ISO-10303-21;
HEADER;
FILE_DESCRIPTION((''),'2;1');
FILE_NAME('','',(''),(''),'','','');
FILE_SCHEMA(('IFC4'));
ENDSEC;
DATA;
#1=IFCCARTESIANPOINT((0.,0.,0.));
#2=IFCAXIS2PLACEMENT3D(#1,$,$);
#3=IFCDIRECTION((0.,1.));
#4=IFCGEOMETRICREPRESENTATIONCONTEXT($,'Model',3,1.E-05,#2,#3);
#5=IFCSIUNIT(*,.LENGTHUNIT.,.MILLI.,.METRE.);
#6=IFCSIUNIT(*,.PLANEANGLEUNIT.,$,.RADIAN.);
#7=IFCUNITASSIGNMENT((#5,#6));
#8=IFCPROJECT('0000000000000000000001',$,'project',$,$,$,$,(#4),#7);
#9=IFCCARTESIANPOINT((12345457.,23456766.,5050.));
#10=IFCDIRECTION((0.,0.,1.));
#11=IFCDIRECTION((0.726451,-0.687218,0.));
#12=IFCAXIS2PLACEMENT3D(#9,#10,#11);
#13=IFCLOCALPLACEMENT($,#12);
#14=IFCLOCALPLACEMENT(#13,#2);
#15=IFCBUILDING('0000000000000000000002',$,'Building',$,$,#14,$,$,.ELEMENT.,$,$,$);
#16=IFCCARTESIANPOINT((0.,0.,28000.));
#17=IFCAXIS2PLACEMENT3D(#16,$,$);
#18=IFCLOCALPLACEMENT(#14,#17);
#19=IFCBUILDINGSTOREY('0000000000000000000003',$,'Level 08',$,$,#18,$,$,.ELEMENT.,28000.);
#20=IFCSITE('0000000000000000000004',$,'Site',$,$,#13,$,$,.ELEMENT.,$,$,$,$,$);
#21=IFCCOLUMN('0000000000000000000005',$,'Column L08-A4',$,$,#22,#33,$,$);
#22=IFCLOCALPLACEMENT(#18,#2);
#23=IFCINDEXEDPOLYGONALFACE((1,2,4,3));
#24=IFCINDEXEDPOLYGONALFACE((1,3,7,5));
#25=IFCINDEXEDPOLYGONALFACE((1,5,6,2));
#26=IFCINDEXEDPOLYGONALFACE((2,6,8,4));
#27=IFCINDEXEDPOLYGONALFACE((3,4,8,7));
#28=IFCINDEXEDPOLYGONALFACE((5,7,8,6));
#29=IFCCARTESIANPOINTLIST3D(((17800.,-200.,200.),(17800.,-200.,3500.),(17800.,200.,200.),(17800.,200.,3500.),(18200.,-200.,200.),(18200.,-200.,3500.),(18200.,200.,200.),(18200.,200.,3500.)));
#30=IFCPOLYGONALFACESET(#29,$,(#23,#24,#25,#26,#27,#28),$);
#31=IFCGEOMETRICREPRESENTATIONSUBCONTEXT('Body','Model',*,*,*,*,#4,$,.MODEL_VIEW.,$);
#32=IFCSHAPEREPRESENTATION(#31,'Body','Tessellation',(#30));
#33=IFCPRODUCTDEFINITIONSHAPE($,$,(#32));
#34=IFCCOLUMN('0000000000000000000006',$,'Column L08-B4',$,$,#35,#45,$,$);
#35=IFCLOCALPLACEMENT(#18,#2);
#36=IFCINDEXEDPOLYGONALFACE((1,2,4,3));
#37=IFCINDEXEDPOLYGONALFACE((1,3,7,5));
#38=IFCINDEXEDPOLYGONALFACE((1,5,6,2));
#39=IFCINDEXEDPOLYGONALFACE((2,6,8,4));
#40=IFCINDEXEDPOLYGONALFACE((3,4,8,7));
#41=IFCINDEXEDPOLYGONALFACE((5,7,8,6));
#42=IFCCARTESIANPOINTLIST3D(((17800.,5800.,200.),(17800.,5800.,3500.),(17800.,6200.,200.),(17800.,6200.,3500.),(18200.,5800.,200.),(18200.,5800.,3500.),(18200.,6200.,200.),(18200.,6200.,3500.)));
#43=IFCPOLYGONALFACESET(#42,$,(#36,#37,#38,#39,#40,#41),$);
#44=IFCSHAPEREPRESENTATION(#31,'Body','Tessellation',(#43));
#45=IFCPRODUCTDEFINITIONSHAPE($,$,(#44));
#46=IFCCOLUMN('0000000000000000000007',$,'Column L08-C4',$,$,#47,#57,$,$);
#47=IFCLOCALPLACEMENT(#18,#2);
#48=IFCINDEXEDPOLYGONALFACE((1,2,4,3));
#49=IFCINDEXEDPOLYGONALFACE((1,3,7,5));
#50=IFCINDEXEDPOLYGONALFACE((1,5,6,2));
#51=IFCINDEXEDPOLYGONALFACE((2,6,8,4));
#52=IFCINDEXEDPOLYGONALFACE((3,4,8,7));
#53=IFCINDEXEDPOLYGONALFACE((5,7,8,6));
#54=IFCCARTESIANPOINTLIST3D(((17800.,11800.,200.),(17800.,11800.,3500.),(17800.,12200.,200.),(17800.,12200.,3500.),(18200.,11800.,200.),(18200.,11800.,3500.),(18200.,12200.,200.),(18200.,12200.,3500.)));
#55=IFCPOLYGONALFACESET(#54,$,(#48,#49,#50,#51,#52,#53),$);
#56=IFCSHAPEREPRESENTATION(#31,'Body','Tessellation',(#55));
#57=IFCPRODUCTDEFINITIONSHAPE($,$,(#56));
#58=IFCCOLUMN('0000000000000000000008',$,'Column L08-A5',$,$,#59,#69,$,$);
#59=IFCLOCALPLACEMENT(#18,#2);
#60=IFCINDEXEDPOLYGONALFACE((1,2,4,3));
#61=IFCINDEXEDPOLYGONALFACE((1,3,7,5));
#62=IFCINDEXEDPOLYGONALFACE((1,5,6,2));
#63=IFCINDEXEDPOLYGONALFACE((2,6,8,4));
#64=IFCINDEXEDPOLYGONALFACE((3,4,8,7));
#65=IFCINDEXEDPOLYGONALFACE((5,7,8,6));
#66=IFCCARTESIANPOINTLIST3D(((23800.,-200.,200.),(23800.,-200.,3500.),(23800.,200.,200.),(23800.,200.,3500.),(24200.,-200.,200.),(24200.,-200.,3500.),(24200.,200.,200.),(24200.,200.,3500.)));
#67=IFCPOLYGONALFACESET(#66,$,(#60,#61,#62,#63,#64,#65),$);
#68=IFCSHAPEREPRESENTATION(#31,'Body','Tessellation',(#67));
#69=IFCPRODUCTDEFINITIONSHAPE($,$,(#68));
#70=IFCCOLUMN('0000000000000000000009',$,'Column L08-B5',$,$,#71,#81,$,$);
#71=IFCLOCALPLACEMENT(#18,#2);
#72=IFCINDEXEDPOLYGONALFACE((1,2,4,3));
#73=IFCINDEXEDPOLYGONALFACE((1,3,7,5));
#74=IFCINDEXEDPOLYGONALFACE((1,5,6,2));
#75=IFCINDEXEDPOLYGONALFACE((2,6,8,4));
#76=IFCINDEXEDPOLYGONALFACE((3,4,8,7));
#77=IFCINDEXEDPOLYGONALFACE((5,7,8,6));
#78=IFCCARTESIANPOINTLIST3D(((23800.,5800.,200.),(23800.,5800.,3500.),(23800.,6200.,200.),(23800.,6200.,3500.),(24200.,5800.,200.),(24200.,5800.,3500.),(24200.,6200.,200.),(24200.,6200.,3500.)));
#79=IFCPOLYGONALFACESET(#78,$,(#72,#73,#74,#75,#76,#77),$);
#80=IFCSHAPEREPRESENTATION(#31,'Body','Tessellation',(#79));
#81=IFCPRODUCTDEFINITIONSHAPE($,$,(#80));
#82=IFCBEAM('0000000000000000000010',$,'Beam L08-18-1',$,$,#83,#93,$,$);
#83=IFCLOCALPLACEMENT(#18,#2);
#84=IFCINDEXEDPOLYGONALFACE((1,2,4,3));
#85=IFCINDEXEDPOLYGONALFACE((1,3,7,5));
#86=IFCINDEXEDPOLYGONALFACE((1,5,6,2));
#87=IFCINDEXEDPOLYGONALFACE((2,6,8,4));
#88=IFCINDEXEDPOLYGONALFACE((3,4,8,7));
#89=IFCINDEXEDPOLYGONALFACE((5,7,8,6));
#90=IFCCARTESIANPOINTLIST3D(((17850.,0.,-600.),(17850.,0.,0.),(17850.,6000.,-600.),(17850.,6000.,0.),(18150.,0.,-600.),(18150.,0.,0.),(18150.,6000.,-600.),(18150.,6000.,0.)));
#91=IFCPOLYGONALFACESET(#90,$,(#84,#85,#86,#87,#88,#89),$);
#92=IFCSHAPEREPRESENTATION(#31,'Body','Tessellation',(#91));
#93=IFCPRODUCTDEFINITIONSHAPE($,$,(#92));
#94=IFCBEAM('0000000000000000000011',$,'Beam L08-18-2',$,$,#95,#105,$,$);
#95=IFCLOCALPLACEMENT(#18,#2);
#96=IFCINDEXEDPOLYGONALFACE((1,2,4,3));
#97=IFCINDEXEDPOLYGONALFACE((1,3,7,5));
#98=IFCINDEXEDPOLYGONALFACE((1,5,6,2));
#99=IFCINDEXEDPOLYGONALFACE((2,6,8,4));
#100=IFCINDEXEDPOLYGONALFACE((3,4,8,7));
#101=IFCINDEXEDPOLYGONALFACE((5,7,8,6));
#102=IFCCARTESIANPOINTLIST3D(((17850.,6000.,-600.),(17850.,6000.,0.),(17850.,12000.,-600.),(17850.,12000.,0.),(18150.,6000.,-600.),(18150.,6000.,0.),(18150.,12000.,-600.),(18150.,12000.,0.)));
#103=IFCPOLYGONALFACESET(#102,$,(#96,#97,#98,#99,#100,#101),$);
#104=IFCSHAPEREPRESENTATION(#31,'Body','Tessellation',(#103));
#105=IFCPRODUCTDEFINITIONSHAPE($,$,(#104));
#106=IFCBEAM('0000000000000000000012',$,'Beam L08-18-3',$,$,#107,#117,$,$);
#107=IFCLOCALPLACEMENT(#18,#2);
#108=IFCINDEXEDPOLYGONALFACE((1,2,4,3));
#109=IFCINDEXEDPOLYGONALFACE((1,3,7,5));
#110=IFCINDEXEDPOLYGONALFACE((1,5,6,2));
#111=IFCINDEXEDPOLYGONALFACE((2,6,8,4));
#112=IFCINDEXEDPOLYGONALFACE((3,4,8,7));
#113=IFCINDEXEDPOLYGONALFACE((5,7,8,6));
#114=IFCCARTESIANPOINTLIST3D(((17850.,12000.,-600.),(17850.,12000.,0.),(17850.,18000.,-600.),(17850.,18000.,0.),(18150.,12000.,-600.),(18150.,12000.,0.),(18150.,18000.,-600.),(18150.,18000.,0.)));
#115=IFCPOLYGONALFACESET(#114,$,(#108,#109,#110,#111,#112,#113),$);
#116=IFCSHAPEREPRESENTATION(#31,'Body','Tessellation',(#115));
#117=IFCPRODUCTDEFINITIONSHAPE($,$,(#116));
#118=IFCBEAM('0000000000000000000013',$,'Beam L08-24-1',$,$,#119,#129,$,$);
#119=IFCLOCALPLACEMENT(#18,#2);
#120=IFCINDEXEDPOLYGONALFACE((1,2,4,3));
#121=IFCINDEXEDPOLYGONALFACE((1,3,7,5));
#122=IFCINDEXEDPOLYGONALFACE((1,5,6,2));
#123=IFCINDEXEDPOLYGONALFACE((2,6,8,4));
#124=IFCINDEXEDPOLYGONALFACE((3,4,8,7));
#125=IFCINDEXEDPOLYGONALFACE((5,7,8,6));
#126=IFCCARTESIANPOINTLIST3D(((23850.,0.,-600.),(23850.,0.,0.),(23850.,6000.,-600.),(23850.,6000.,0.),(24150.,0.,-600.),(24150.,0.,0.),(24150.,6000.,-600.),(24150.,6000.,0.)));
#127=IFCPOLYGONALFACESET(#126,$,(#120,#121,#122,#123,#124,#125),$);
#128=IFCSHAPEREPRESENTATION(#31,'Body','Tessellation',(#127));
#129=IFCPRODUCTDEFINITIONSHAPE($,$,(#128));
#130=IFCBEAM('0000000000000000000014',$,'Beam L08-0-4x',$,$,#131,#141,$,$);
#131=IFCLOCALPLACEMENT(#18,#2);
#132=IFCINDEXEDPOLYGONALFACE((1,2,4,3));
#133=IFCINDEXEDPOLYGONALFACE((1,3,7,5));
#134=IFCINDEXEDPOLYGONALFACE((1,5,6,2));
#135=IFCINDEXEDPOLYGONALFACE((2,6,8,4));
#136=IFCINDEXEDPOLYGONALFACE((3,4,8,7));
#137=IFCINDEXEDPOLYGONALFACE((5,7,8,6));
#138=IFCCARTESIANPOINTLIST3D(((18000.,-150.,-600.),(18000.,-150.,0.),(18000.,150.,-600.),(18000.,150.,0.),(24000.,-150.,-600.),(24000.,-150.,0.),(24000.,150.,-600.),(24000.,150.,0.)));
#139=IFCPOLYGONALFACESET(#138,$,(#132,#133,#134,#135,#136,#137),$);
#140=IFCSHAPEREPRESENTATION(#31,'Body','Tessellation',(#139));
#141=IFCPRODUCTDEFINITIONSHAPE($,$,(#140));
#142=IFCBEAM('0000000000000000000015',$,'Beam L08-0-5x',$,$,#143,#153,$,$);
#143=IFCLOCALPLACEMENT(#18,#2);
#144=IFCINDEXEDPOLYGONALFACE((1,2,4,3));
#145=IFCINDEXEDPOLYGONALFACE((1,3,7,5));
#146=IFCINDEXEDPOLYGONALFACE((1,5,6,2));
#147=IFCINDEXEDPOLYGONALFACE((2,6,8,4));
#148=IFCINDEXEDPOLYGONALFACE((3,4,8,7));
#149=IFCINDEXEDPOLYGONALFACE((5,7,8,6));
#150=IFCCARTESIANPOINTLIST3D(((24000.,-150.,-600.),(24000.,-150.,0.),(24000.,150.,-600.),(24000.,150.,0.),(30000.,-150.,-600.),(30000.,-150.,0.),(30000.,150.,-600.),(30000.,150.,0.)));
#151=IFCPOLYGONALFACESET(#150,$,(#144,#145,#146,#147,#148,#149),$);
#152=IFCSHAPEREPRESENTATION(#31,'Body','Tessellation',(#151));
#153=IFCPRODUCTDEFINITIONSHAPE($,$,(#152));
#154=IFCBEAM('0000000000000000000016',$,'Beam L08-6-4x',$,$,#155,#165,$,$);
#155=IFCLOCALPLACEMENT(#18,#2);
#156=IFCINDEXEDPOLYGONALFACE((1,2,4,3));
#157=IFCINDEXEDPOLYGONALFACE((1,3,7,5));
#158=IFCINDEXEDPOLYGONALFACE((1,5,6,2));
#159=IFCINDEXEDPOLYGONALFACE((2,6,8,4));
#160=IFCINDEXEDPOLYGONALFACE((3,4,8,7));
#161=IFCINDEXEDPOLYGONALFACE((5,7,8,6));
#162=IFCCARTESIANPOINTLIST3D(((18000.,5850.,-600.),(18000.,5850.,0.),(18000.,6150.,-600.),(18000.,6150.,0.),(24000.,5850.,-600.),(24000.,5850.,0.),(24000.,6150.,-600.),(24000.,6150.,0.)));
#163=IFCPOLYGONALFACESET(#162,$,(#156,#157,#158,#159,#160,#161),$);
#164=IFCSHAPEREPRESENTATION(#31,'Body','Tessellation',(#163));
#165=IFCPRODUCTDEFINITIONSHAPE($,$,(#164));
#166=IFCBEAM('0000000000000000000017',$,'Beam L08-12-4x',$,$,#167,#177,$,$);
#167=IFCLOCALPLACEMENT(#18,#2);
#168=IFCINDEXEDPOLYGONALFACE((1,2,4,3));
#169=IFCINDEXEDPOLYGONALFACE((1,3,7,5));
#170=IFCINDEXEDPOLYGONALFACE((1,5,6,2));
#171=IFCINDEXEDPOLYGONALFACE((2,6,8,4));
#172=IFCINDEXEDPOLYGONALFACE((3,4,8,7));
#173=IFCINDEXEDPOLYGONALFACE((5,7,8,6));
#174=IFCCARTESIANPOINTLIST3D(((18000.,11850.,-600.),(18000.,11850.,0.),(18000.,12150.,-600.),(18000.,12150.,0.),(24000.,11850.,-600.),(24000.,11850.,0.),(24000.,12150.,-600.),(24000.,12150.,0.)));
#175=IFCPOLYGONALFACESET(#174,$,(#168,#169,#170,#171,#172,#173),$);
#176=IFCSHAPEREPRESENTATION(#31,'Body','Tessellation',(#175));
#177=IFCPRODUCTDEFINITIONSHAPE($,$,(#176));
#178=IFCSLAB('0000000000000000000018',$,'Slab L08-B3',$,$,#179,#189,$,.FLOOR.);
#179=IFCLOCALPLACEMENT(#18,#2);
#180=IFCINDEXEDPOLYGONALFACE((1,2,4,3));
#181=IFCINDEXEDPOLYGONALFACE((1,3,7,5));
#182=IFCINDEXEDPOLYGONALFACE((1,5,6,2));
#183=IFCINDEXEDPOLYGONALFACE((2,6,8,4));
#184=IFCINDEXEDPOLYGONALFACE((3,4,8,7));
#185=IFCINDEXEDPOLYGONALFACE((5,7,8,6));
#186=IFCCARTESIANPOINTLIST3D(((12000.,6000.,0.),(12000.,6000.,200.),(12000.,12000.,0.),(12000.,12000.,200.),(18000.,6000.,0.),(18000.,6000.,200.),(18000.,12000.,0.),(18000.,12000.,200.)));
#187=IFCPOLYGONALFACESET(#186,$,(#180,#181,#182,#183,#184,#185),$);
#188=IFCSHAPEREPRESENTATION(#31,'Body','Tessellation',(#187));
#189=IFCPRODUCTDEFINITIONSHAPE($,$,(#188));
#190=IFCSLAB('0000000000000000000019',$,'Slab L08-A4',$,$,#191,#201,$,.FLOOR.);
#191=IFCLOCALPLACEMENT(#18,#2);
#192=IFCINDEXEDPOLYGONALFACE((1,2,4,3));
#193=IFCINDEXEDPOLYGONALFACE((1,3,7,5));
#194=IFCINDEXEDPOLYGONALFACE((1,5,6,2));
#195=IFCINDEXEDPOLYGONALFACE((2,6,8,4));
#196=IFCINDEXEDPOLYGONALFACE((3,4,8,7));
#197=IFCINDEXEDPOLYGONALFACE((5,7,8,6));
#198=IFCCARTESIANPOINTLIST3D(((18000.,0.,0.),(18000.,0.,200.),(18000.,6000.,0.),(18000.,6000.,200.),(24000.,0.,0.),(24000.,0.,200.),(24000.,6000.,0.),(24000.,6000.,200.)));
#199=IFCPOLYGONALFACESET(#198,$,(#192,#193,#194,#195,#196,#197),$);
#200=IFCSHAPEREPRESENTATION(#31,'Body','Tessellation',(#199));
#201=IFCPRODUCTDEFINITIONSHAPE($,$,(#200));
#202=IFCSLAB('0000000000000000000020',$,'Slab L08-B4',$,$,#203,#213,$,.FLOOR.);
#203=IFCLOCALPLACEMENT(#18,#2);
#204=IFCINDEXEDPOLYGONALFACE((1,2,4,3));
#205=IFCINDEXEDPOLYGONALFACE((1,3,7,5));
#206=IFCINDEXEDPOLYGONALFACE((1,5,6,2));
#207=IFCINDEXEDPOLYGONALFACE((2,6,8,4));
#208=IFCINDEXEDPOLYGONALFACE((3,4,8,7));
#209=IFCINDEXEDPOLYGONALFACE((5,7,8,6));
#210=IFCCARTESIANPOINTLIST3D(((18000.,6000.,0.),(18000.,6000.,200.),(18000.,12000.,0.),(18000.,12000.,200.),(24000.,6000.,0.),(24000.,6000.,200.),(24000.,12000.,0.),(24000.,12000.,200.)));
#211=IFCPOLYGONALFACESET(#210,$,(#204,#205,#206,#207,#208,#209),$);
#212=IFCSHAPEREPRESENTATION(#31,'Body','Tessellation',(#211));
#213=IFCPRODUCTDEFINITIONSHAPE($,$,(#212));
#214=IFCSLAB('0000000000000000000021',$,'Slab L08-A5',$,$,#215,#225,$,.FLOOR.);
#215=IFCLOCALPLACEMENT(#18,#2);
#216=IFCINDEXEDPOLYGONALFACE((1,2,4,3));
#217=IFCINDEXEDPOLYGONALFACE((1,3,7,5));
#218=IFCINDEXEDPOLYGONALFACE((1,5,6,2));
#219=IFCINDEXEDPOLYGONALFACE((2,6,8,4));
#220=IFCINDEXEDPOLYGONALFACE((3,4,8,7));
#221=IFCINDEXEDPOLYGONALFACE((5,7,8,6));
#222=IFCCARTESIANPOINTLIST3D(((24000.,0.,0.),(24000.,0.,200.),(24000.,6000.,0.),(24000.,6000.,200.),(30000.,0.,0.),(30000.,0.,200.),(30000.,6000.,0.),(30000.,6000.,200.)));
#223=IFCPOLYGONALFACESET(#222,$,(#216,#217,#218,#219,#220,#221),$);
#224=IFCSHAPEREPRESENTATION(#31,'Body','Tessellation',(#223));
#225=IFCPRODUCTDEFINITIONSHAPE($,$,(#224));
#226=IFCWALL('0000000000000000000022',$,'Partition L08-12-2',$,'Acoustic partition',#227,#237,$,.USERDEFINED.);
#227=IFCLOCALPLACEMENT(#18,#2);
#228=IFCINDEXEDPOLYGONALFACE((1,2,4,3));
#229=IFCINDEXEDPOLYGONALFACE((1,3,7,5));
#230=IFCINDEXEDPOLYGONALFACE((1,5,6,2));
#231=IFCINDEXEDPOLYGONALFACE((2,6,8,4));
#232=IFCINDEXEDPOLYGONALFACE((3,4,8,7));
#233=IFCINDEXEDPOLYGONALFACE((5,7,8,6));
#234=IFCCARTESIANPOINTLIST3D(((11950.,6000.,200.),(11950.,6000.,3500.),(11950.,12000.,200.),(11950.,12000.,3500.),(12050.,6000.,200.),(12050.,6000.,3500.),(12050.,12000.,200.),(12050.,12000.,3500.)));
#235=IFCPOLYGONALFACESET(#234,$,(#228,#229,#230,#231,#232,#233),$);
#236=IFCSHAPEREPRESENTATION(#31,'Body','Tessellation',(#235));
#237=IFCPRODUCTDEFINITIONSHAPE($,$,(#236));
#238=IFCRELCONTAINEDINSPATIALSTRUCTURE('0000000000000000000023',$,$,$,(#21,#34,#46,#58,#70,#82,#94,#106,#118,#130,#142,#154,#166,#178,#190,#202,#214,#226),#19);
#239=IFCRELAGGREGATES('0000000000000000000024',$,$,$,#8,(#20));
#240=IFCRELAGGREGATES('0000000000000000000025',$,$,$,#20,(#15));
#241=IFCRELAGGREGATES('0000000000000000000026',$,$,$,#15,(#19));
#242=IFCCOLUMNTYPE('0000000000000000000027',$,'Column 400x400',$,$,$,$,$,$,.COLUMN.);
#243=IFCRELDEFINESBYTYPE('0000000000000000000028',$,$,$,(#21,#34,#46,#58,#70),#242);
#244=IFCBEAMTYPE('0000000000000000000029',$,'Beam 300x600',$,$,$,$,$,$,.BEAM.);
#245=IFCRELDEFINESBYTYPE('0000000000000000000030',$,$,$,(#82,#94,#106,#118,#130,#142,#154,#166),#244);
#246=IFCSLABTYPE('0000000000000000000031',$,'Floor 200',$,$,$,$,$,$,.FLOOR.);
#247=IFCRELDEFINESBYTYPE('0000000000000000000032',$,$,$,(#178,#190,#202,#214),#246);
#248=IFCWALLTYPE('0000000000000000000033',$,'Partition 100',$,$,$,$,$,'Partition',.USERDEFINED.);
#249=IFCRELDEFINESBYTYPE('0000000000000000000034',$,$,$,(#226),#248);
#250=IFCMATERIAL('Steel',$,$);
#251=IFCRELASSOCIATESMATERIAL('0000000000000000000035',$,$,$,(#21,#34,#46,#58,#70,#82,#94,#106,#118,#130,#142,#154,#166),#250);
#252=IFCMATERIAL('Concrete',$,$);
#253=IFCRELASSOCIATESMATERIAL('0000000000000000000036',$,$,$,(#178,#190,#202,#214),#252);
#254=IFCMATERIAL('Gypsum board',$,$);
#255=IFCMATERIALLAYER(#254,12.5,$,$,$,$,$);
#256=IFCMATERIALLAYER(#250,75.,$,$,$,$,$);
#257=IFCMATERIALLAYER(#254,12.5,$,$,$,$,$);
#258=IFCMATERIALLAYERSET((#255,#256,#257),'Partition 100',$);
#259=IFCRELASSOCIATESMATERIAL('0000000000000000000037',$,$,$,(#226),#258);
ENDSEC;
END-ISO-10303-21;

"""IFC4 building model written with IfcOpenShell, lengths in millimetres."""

from ifc_helpers import new_model, si_unit, direction, frame, origin, place, context, subcontext, project, spatial, rectangle, extrude, material, layer, layer_set, layer_usage, type_object, element, save


model = new_model("IFC4")

# Units and contexts
model_context = context("Model", 3, precision=1e-05, world=origin(), true_north=direction((0.0, 1.0)))
body_context = subcontext(model_context, "Body", "Model", "MODEL_VIEW")
ifc_project = project(units=[si_unit("LENGTHUNIT", "METRE", prefix="MILLI"), si_unit("PLANEANGLEUNIT", "RADIAN")], contexts=[model_context])

# Site, building, storey
site_placement = place(None, frame((12345457.0, 23456766.0, 5050.0), z_axis=(0.0, 0.0, 1.0), x_axis=(0.726451, -0.687218, 0.0)))
site = spatial("IfcSite", under=ifc_project, at=site_placement, Name="Site", CompositionType="ELEMENT")
building_placement = place(site_placement, origin())
building = spatial("IfcBuilding", under=site, at=building_placement, Name="Building", CompositionType="ELEMENT")
storey_placement = place(building_placement, frame((0.0, 0.0, 28000.0)))
storey = spatial("IfcBuildingStorey", under=building, at=storey_placement, Name="Level 08", CompositionType="ELEMENT", Elevation=28000.0)

# Columns
ifc_material_1 = material(Name="Steel")
column_type = type_object("IfcColumnType", Name="Column 400x400", PredefinedType="COLUMN")
for number, where, name in (
    (1, (17800.0, -200.0, 200.0), "Column L08-A4"),
    (2, (17800.0, 5800.0, 200.0), "Column L08-B4"),
    (3, (17800.0, 11800.0, 200.0), "Column L08-C4"),
    (4, (23800.0, -200.0, 200.0), "Column L08-A5"),
    (5, (23800.0, 5800.0, 200.0), "Column L08-B5"),
):
    element("IfcColumn", number, at=place(storey_placement, frame(where)), inside=storey, type_object=column_type, material=ifc_material_1, Name=name, context=body_context, shape_type="SweptSolid", body=[
        extrude(rectangle(XDim=400.0, YDim=400.0), frame((200.0, 200.0, 0.0)), (0.0, 0.0, 1.0), 3300.0),
    ])

# Beams
beam_type = type_object("IfcBeamType", Name="Beam 300x600", PredefinedType="BEAM")
for number, where, name in (
    (6, (17850.0, 0.0, -600.0), "Beam L08-18-1"),
    (7, (17850.0, 6000.0, -600.0), "Beam L08-18-2"),
    (8, (17850.0, 12000.0, -600.0), "Beam L08-18-3"),
    (9, (23850.0, 0.0, -600.0), "Beam L08-24-1"),
):
    element("IfcBeam", number, at=place(storey_placement, frame(where)), inside=storey, type_object=beam_type, material=ifc_material_1, Name=name, context=body_context, shape_type="SweptSolid", body=[
        extrude(rectangle(XDim=300.0, YDim=6000.0), frame((150.0, 3000.0, 0.0)), (0.0, 0.0, 1.0), 600.0),
    ])
for number, where, name in (
    (10, (18000.0, -150.0, -600.0), "Beam L08-0-4x"),
    (11, (24000.0, -150.0, -600.0), "Beam L08-0-5x"),
    (12, (18000.0, 5850.0, -600.0), "Beam L08-6-4x"),
    (13, (18000.0, 11850.0, -600.0), "Beam L08-12-4x"),
):
    element("IfcBeam", number, at=place(storey_placement, frame(where)), inside=storey, type_object=beam_type, material=ifc_material_1, Name=name, context=body_context, shape_type="SweptSolid", body=[
        extrude(rectangle(XDim=6000.0, YDim=300.0), frame((3000.0, 150.0, 0.0)), (0.0, 0.0, 1.0), 600.0),
    ])

# Slabs
ifc_material_2 = material(Name="Concrete")
slab_type = type_object("IfcSlabType", Name="Floor 200", PredefinedType="FLOOR")
for number, where, name in (
    (14, (12000.0, 6000.0, 0.0), "Slab L08-B3"),
    (15, (18000.0, 0.0, 0.0), "Slab L08-A4"),
    (16, (18000.0, 6000.0, 0.0), "Slab L08-B4"),
    (17, (24000.0, 0.0, 0.0), "Slab L08-A5"),
):
    element("IfcSlab", number, at=place(storey_placement, frame(where)), inside=storey, type_object=slab_type, material=ifc_material_2, Name=name, PredefinedType="FLOOR", context=body_context, shape_type="SweptSolid", body=[
        extrude(rectangle(XDim=6000.0, YDim=6000.0), frame((3000.0, 3000.0, 0.0)), (0.0, 0.0, 1.0), 200.0),
    ])

# Wall
ifc_material_3 = material(Name="Gypsum board")
ifc_layer_1 = layer(ifc_material_3, 12.5)
ifc_layer_2 = layer(ifc_material_1, 75.0)
ifc_layer_3 = layer(ifc_material_3, 12.5)
ifc_layer_set = layer_set([ifc_layer_1, ifc_layer_2, ifc_layer_3], Name="Partition 100")
ifc_layer_usage = layer_usage(ifc_layer_set, "AXIS2", "POSITIVE", 0.0)
wall_type = type_object("IfcWallType", Name="Partition 100", ElementType="Partition", PredefinedType="USERDEFINED")
for number, where, name in (
    (18, (11950.0, 6000.0, 200.0), "Partition L08-12-2"),
):
    element("IfcWall", number, at=place(storey_placement, frame(where)), inside=storey, type_object=wall_type, material=ifc_layer_usage, Name=name, ObjectType="Acoustic partition", PredefinedType="USERDEFINED", context=body_context, shape_type="SweptSolid", body=[
        extrude(rectangle(XDim=100.0, YDim=6000.0), frame((50.0, 3000.0, 0.0)), (0.0, 0.0, 1.0), 3300.0),
    ])

save(model, "model.ifc")
